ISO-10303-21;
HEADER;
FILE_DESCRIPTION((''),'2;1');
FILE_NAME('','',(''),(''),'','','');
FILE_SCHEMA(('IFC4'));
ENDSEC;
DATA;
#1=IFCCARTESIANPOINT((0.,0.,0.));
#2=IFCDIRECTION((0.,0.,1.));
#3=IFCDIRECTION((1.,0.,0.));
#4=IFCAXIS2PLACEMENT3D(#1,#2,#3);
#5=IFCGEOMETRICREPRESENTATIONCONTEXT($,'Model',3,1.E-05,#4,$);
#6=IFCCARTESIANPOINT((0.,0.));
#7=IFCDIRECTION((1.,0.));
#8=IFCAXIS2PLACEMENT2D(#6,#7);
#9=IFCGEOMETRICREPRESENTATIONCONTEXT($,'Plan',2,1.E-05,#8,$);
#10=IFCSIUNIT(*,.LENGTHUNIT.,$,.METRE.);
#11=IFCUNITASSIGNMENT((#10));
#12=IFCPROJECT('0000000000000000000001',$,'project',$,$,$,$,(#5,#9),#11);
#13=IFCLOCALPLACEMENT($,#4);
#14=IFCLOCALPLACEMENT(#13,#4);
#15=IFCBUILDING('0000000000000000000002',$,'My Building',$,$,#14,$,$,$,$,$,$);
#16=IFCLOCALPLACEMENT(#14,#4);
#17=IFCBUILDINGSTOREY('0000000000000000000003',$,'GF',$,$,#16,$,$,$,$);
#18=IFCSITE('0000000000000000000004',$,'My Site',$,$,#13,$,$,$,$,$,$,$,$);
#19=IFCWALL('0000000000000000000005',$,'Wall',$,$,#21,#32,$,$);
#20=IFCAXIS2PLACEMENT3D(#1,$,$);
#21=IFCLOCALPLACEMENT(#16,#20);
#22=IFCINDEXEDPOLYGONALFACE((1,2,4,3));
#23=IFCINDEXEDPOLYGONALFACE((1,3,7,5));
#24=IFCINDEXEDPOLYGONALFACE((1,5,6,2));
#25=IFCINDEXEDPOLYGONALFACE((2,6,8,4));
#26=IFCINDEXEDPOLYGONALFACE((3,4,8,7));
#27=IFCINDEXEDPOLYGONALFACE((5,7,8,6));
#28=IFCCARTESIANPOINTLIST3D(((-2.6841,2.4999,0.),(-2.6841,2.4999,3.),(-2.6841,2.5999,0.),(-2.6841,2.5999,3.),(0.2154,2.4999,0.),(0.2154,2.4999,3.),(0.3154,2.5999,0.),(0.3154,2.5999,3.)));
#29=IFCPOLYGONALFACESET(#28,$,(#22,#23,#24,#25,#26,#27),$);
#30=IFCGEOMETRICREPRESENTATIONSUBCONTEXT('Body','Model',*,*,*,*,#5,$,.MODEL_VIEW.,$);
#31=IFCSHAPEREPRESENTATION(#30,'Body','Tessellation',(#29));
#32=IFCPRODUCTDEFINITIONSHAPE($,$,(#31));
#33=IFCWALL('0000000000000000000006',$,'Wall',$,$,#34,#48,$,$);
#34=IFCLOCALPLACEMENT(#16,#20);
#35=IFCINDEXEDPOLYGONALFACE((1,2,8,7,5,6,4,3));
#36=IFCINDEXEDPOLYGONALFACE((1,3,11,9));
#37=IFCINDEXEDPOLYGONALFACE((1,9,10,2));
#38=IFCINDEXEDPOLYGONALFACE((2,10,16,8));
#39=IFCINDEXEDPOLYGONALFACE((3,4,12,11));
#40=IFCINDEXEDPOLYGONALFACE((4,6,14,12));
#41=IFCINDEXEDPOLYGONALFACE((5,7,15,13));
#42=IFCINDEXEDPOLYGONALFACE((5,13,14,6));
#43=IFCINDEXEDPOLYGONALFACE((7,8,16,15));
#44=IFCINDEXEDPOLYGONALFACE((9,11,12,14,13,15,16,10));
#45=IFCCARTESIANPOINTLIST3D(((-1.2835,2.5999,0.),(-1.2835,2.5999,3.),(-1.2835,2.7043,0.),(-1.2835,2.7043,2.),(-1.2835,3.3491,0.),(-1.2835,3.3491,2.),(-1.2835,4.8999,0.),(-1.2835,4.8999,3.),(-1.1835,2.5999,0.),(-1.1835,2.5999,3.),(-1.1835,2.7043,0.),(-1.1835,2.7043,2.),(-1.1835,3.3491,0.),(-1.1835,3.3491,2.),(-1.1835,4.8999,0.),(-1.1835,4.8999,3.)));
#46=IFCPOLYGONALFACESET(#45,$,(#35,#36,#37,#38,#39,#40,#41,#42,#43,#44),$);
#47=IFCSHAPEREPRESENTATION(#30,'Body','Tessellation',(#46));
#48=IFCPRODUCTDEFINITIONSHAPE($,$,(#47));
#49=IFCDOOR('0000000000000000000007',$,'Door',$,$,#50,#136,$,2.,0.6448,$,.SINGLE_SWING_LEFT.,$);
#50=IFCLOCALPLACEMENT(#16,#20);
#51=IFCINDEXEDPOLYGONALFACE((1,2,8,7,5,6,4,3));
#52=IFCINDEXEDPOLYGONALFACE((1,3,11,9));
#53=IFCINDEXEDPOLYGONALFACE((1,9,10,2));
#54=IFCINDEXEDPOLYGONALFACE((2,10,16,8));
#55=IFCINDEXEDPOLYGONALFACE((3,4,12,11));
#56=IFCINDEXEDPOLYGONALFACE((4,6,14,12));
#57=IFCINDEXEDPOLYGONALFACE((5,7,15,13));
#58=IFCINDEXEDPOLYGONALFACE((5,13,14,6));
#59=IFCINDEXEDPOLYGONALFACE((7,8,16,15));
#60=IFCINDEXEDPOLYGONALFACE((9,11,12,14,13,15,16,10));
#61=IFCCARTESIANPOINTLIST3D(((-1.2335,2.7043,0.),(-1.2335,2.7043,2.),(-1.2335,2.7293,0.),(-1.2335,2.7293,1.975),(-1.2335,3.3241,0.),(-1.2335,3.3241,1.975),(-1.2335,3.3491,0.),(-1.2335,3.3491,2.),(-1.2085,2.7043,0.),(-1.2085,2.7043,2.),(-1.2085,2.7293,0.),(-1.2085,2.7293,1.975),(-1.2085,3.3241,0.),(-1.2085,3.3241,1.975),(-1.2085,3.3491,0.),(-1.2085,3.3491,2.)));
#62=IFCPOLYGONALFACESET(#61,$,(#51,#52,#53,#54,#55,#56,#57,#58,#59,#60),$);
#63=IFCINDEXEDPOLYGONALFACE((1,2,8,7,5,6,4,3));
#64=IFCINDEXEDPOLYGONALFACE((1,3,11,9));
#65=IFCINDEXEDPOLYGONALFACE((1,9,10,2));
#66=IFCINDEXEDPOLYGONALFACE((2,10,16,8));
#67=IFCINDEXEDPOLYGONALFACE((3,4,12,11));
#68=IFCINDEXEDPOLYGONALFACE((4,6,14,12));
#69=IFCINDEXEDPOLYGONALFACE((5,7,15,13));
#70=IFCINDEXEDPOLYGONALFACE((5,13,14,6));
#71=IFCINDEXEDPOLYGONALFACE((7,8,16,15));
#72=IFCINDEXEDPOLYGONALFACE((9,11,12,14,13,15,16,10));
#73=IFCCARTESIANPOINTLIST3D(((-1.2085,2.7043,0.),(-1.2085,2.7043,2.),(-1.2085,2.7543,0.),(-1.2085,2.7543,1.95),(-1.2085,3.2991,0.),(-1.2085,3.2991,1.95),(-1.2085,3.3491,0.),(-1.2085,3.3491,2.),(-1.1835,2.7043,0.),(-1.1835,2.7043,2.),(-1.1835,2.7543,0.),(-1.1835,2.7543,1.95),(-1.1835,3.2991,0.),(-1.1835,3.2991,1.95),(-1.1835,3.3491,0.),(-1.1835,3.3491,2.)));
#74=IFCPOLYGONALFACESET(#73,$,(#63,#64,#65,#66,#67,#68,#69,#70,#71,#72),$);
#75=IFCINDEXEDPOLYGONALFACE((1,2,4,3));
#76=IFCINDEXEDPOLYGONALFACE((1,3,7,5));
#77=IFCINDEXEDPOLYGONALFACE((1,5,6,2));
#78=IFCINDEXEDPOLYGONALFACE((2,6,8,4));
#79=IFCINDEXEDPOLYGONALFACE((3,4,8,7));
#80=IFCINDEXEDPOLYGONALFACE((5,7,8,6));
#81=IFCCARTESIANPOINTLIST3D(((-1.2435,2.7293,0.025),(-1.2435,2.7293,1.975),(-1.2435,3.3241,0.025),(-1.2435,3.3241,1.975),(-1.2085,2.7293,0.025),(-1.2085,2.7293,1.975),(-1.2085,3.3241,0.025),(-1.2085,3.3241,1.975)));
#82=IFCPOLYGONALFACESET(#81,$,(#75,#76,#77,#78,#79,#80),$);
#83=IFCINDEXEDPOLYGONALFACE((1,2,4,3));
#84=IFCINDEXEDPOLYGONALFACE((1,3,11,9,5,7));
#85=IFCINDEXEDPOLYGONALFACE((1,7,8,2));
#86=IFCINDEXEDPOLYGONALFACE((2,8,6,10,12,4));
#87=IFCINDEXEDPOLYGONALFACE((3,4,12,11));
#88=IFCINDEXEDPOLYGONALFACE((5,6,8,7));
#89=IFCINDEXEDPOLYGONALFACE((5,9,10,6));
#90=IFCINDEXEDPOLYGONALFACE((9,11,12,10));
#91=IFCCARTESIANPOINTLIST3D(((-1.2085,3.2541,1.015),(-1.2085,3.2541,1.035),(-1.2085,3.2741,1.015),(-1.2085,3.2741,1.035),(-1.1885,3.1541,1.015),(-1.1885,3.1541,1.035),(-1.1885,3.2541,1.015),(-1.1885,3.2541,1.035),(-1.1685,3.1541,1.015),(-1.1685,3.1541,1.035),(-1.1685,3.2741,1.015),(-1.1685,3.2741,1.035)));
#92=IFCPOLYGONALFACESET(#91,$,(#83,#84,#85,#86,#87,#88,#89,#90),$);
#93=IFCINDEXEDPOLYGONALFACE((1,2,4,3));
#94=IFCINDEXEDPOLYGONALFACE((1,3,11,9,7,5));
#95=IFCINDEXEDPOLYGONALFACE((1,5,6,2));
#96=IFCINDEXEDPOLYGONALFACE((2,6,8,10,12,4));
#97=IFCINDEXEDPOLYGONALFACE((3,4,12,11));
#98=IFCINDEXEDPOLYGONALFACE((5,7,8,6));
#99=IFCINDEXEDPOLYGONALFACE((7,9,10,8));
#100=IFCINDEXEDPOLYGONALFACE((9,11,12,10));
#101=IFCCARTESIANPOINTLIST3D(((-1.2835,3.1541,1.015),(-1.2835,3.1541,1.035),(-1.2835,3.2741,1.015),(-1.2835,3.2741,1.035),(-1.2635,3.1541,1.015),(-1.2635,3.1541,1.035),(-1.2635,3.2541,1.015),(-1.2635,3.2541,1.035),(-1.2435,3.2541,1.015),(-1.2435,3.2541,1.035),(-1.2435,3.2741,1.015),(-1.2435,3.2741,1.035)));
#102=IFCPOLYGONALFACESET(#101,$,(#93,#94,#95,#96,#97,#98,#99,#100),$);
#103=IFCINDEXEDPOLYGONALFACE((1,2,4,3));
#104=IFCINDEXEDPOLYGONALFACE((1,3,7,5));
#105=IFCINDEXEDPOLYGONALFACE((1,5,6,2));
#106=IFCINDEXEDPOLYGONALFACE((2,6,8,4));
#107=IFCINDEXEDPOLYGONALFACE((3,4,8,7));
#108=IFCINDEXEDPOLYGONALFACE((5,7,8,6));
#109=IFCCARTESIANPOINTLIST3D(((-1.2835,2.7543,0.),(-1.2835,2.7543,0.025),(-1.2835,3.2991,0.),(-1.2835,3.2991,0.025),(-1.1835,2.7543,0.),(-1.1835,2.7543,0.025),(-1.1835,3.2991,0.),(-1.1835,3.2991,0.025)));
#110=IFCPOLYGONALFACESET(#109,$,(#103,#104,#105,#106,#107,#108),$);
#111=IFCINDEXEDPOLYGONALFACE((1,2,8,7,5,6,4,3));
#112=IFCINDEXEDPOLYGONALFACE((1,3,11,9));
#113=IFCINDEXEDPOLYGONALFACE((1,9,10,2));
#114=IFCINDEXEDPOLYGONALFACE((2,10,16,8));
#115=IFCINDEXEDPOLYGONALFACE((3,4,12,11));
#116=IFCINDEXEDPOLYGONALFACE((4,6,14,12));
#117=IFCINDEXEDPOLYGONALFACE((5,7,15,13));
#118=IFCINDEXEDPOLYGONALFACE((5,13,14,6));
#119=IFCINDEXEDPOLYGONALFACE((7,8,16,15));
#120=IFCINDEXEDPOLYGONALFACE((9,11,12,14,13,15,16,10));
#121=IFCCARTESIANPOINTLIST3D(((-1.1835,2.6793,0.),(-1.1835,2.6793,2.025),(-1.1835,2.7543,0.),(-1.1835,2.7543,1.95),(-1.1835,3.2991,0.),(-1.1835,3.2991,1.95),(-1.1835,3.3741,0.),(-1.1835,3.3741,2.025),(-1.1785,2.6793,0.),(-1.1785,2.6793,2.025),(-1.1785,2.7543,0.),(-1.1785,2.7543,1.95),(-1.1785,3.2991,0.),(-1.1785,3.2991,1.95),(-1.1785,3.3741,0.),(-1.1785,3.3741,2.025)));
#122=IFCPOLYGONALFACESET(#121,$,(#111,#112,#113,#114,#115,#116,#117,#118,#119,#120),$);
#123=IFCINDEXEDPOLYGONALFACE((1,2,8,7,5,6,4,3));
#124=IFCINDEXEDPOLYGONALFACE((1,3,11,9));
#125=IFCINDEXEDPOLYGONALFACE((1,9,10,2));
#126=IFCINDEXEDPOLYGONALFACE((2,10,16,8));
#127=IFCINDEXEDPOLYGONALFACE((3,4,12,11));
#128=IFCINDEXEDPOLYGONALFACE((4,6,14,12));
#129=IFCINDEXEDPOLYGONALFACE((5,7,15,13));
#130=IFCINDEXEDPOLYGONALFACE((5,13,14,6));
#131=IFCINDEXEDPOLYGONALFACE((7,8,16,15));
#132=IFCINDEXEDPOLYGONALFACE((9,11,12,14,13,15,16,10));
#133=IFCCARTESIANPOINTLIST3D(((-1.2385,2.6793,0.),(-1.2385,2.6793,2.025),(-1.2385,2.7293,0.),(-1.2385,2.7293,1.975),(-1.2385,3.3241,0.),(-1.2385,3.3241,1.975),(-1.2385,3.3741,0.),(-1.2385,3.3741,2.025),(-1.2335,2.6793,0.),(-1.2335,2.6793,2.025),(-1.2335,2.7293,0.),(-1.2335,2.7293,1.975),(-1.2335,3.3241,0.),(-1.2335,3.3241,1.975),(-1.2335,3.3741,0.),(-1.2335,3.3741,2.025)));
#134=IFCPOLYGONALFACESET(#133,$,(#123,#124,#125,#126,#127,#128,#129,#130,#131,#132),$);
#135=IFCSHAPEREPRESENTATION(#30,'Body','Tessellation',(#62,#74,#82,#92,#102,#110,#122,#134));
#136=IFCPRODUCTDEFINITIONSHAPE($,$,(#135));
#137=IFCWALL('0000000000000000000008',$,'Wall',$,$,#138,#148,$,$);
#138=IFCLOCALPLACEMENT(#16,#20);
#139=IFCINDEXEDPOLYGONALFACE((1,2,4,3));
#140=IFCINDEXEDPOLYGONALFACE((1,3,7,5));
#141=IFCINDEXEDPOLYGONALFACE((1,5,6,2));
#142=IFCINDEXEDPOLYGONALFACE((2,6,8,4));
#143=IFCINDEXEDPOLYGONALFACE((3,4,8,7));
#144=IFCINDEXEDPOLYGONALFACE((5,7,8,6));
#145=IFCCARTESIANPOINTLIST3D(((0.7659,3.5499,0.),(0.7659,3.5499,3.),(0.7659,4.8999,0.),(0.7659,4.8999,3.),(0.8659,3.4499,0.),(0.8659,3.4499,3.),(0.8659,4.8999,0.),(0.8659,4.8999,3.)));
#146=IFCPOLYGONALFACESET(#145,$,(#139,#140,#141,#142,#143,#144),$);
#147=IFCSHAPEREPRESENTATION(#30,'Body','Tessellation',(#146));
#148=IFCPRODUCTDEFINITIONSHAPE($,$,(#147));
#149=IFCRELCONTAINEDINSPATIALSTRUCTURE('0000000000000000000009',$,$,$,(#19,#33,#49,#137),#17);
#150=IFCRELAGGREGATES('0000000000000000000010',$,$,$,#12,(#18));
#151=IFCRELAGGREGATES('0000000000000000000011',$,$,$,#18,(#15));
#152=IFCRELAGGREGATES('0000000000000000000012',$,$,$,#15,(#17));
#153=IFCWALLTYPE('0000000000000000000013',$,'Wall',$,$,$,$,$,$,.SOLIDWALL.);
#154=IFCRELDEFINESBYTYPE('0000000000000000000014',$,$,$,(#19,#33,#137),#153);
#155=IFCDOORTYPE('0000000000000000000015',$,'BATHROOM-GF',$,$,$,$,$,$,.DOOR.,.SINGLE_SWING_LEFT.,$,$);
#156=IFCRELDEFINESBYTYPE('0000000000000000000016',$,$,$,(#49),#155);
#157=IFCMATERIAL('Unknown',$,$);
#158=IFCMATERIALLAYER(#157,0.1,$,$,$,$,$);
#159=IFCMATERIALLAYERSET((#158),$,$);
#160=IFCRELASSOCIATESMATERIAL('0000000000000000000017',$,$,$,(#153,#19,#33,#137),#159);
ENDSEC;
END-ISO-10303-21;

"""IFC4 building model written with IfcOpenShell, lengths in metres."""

from ifc_helpers import new_model, entity, si_unit, frame, origin_with_axes, origin_2d_with_axis, place, context, subcontext, project, spatial, line, indexed_curve, outline, extrude, shape, source, transform, mapped, material, layer, layer_set, layer_usage, type_object, type_shapes, element, fill, save


model = new_model("IFC4")

# Units and contexts
model_context = context("Model", 3, precision=1e-05, world=origin_with_axes())
plan_context = context("Plan", 2, precision=1e-05, world=origin_2d_with_axis())
body_context_1 = subcontext(model_context, "Body", "Model", "MODEL_VIEW")
body_context_2 = subcontext(plan_context, "Body", "Plan", "PLAN_VIEW")
ifc_project = project(units=[si_unit("LENGTHUNIT", "METRE")], contexts=[model_context, plan_context])

# Site, building, storey
site_placement = place(None, origin_with_axes())
site = spatial("IfcSite", under=ifc_project, at=site_placement, Name="My Site")
building_placement = place(site_placement, origin_with_axes())
building = spatial("IfcBuilding", under=site, at=building_placement, Name="My Building")
storey_placement = place(building_placement, origin_with_axes())
storey = spatial("IfcBuildingStorey", under=building, at=storey_placement, Name="GF")

# Shared definitions
ifc_material_1 = material(Name="Unknown")

# Shared definitions
ifc_layer_1 = layer(ifc_material_1, 0.1)
ifc_layer_set_1 = layer_set([ifc_layer_1])
wall_type = type_object("IfcWallType", Name="Wall", PredefinedType="SOLIDWALL", material=ifc_layer_set_1)

# Wall
ifc_layer_usage_1 = layer_usage(ifc_layer_set_1, "AXIS2", "POSITIVE", 0.0)
wall_1_placement = place(storey_placement, frame((0.3154, 2.5999, 0.0), z_axis=(0.0, 0.0, 1.0), x_axis=(-1.0, 0.0, 0.0)))
element("IfcWall", 1, at=wall_1_placement, inside=storey, type_object=wall_type, material=ifc_layer_usage_1, Name="Wall", context=body_context_1, shape_type="SweptSolid", body=[
    extrude(outline(indexed_curve([(0.0, 0.0), (0.1, 0.1), (2.9996, 0.1), (2.9996, 0.0)], segments=[line(1, 2, 3, 4, 1)])), origin_with_axes(), (0.0, 0.0, 1.0), 3.0),
])

# Wall, opening, door
ifc_layer_usage_2 = layer_usage(ifc_layer_set_1, "AXIS2", "POSITIVE", 0.0)
wall_2_placement = place(storey_placement, frame((-1.1835, 2.5999, 0.0), z_axis=(0.0, 0.0, 1.0), x_axis=(0.0, 1.0, 0.0)))
wall_2 = element("IfcWall", 2, at=wall_2_placement, inside=storey, type_object=wall_type, material=ifc_layer_usage_2, Name="Wall", context=body_context_1, shape_type="SweptSolid", body=[
    extrude(outline(indexed_curve([(0.0, 0.0), (0.0, 0.1), (2.3, 0.1), (2.3, 0.0)], segments=[line(1, 2, 3, 4, 1)])), origin_with_axes(), (0.0, 0.0, 1.0), 3.0),
])
shared_shape_1 = source(origin_with_axes(), body_context_1, "Body", "SweptSolid", [
    extrude(outline(indexed_curve([(0.0, 0.0), (0.6448, 0.0), (0.6448, 2.0), (0.0, 2.0)], segments=[line(1, 2, 3, 4, 1)])), frame((0.0, -0.6, 0.0), z_axis=(0.0, -1.0, 0.0), x_axis=(1.0, 0.0, 0.0)), (0.0, 0.0, -1.0), 1.2),
])
opening_1_placement = place(wall_2_placement, frame((0.1044, 0.0, 0.0), z_axis=(0.0, 0.0, 1.0), x_axis=(1.0, 0.0, 0.0)))
opening_1 = element("IfcOpeningElement", 3, at=opening_1_placement, cuts=wall_2, PredefinedType="OPENING", context=body_context_1, shape_type="MappedRepresentation", body=[
    mapped(shared_shape_1, transform((0.0, 0.0, 0.0), x_axis=(1.0, 0.0, 0.0), y_axis=(0.0, 1.0, 0.0), z_axis=(0.0, 0.0, 1.0), scale=1.0)),
])
door_type_1 = type_object("IfcDoorType", Name="BATHROOM-GF", OperationType="SINGLE_SWING_LEFT", PredefinedType="DOOR")
shared_shape_2 = source(origin_with_axes(), body_context_1, "Body", "SweptSolid", [
    extrude(outline(indexed_curve([(0.0, 0.0), (0.0, 2.0), (0.6448, 2.0), (0.6448, 0.0), (0.6198, 0.0), (0.6198, 1.975), (0.025, 1.975), (0.025, 0.0)], segments=[line(1, 2, 3, 4, 5, 6, 7, 8, 1)])), frame((0.0, 0.025, 0.0), z_axis=(0.0, -1.0, 0.0), x_axis=(1.0, 0.0, 0.0)), (0.0, 0.0, -1.0), 0.025),
    extrude(outline(indexed_curve([(0.0, 0.0), (0.0, 2.0), (0.6448, 2.0), (0.6448, 0.0), (0.5948, 0.0), (0.5948, 1.95), (0.05, 1.95), (0.05, 0.0)], segments=[line(1, 2, 3, 4, 5, 6, 7, 8, 1)])), frame((0.0, 0.0, 0.0), z_axis=(0.0, -1.0, 0.0), x_axis=(1.0, 0.0, 0.0)), (0.0, 0.0, -1.0), 0.025),
    extrude(outline(indexed_curve([(0.0, 0.0), (0.5948, 0.0), (0.5948, 0.035), (0.0, 0.035)], segments=[line(1, 2, 3, 4, 1)])), frame((0.025, 0.025, 0.025), z_axis=(0.0, 0.0, 1.0), x_axis=(1.0, 0.0, 0.0)), (0.0, 0.0, 1.0), 1.95),
    extrude(outline(indexed_curve([(0.0, 0.0), (0.0, -0.04), (-0.12, -0.04), (-0.12, -0.02), (-0.02, -0.02), (-0.02, 0.0)], segments=[line(1, 2, 3, 4, 5, 6, 1)])), frame((0.5698, 0.025, 1.015), z_axis=(0.0, 0.0, 1.0), x_axis=(1.0, 0.0, 0.0)), (0.0, 0.0, 1.0), 0.02),
    extrude(outline(indexed_curve([(0.0, 0.0), (0.0, 0.04), (-0.12, 0.04), (-0.12, 0.02), (-0.02, 0.02), (-0.02, 0.0)], segments=[line(1, 2, 3, 4, 5, 6, 1)])), frame((0.5698, 0.06, 1.015), z_axis=(0.0, 0.0, 1.0), x_axis=(1.0, 0.0, 0.0)), (0.0, 0.0, 1.0), 0.02),
    extrude(outline(indexed_curve([(0.0, 0.0), (0.5448, 0.0), (0.5448, 0.1), (0.0, 0.1)], segments=[line(1, 2, 3, 4, 1)])), frame((0.05, 0.0, 0.0), z_axis=(0.0, 0.0, 1.0), x_axis=(1.0, 0.0, 0.0)), (0.0, 0.0, 1.0), 0.025),
    extrude(outline(indexed_curve([(0.0, 0.0), (0.0, 2.025), (0.6948, 2.025), (0.6948, 0.0), (0.6198, 0.0), (0.6198, 1.95), (0.075, 1.95), (0.075, 0.0)], segments=[line(1, 2, 3, 4, 5, 6, 7, 8, 1)])), frame((-0.025, -0.005, 0.0), z_axis=(0.0, -1.0, 0.0), x_axis=(1.0, 0.0, 0.0)), (0.0, 0.0, -1.0), 0.005),
    extrude(outline(indexed_curve([(0.0, 0.0), (0.0, 2.025), (0.6948, 2.025), (0.6948, 0.0), (0.6448, 0.0), (0.6448, 1.975), (0.05, 1.975), (0.05, 0.0)], segments=[line(1, 2, 3, 4, 5, 6, 7, 8, 1)])), frame((-0.025, 0.05, 0.0), z_axis=(0.0, -1.0, 0.0), x_axis=(1.0, 0.0, 0.0)), (0.0, 0.0, -1.0), 0.005),
])
shared_shape_3 = source(origin_with_axes(), body_context_2, "Body", "Curve2D", [
    entity("IfcIndexedPolyCurve", entity("IfcCartesianPointList2D", [[0.0, 0.0], [0.0, 0.05], [0.025, 0.05], [0.025, 0.025], [0.05, 0.025], [0.05, 0.0]]), [entity("IfcLineIndex", [1, 2, 3, 4, 5, 6, 1])]),
    entity("IfcIndexedPolyCurve", entity("IfcCartesianPointList2D", [[0.6448, 0.0], [0.6448, 0.05], [0.6198, 0.05], [0.6198, 0.025], [0.5948, 0.025], [0.5948, 0.0]]), [entity("IfcLineIndex", [1, 2, 3, 4, 5, 6, 1])]),
    entity("IfcTrimmedCurve", entity("IfcEllipse", entity("IfcAxis2Placement2D", entity("IfcCartesianPoint", [0.06, 0.05]), entity("IfcDirection", [1.0, 0.0])), 0.5598, 0.5948), [entity("IfcCartesianPoint", [0.6198, 0.05])], [entity("IfcCartesianPoint", [0.06, 0.6448])], True, "CARTESIAN"),
    entity("IfcIndexedPolyCurve", entity("IfcCartesianPointList2D", [[0.025, 0.05], [0.06, 0.05], [0.06, 0.6448], [0.025, 0.6448]]), [entity("IfcLineIndex", [1, 2, 3, 4, 1])]),
])
type_shapes(door_type_1, [shared_shape_2, shared_shape_3])
door_1_placement = place(opening_1_placement, frame((0.0, 0.0, 0.0), z_axis=(0.0, 0.0, 1.0), x_axis=(1.0, 0.0, 0.0)))
door_1 = element("IfcDoor", 4, at=door_1_placement, inside=storey, type_object=door_type_1, Name="Door", OperationType="SINGLE_SWING_LEFT", OverallHeight=2.0, OverallWidth=0.6448, shapes=[
    shape(body_context_1, "Body", "MappedRepresentation", [mapped(shared_shape_2, transform((0.0, 0.0, 0.0), x_axis=(1.0, 0.0, 0.0), y_axis=(0.0, 1.0, 0.0), z_axis=(0.0, 0.0, 1.0), scale=1.0))]),
    shape(body_context_2, "Body", "MappedRepresentation", [mapped(shared_shape_3, transform((0.0, 0.0, 0.0), x_axis=(1.0, 0.0, 0.0), y_axis=(0.0, 1.0, 0.0), z_axis=(0.0, 0.0, 1.0), scale=1.0))]),
])
fill(opening_1, door_1)

# Wall
ifc_layer_usage_3 = layer_usage(ifc_layer_set_1, "AXIS2", "POSITIVE", 0.0)
wall_3_placement = place(storey_placement, frame((0.7659, 4.8999, 0.0), z_axis=(0.0, 0.0, 1.0), x_axis=(0.0, -1.0, 0.0)))
element("IfcWall", 5, at=wall_3_placement, inside=storey, type_object=wall_type, material=ifc_layer_usage_3, Name="Wall", context=body_context_1, shape_type="SweptSolid", body=[
    extrude(outline(indexed_curve([(0.0, 0.0), (0.0, 0.1), (1.45, 0.1), (1.35, 0.0)], segments=[line(1, 2, 3, 4, 1)])), origin_with_axes(), (0.0, 0.0, 1.0), 3.0),
])

save(model, "model.ifc")
